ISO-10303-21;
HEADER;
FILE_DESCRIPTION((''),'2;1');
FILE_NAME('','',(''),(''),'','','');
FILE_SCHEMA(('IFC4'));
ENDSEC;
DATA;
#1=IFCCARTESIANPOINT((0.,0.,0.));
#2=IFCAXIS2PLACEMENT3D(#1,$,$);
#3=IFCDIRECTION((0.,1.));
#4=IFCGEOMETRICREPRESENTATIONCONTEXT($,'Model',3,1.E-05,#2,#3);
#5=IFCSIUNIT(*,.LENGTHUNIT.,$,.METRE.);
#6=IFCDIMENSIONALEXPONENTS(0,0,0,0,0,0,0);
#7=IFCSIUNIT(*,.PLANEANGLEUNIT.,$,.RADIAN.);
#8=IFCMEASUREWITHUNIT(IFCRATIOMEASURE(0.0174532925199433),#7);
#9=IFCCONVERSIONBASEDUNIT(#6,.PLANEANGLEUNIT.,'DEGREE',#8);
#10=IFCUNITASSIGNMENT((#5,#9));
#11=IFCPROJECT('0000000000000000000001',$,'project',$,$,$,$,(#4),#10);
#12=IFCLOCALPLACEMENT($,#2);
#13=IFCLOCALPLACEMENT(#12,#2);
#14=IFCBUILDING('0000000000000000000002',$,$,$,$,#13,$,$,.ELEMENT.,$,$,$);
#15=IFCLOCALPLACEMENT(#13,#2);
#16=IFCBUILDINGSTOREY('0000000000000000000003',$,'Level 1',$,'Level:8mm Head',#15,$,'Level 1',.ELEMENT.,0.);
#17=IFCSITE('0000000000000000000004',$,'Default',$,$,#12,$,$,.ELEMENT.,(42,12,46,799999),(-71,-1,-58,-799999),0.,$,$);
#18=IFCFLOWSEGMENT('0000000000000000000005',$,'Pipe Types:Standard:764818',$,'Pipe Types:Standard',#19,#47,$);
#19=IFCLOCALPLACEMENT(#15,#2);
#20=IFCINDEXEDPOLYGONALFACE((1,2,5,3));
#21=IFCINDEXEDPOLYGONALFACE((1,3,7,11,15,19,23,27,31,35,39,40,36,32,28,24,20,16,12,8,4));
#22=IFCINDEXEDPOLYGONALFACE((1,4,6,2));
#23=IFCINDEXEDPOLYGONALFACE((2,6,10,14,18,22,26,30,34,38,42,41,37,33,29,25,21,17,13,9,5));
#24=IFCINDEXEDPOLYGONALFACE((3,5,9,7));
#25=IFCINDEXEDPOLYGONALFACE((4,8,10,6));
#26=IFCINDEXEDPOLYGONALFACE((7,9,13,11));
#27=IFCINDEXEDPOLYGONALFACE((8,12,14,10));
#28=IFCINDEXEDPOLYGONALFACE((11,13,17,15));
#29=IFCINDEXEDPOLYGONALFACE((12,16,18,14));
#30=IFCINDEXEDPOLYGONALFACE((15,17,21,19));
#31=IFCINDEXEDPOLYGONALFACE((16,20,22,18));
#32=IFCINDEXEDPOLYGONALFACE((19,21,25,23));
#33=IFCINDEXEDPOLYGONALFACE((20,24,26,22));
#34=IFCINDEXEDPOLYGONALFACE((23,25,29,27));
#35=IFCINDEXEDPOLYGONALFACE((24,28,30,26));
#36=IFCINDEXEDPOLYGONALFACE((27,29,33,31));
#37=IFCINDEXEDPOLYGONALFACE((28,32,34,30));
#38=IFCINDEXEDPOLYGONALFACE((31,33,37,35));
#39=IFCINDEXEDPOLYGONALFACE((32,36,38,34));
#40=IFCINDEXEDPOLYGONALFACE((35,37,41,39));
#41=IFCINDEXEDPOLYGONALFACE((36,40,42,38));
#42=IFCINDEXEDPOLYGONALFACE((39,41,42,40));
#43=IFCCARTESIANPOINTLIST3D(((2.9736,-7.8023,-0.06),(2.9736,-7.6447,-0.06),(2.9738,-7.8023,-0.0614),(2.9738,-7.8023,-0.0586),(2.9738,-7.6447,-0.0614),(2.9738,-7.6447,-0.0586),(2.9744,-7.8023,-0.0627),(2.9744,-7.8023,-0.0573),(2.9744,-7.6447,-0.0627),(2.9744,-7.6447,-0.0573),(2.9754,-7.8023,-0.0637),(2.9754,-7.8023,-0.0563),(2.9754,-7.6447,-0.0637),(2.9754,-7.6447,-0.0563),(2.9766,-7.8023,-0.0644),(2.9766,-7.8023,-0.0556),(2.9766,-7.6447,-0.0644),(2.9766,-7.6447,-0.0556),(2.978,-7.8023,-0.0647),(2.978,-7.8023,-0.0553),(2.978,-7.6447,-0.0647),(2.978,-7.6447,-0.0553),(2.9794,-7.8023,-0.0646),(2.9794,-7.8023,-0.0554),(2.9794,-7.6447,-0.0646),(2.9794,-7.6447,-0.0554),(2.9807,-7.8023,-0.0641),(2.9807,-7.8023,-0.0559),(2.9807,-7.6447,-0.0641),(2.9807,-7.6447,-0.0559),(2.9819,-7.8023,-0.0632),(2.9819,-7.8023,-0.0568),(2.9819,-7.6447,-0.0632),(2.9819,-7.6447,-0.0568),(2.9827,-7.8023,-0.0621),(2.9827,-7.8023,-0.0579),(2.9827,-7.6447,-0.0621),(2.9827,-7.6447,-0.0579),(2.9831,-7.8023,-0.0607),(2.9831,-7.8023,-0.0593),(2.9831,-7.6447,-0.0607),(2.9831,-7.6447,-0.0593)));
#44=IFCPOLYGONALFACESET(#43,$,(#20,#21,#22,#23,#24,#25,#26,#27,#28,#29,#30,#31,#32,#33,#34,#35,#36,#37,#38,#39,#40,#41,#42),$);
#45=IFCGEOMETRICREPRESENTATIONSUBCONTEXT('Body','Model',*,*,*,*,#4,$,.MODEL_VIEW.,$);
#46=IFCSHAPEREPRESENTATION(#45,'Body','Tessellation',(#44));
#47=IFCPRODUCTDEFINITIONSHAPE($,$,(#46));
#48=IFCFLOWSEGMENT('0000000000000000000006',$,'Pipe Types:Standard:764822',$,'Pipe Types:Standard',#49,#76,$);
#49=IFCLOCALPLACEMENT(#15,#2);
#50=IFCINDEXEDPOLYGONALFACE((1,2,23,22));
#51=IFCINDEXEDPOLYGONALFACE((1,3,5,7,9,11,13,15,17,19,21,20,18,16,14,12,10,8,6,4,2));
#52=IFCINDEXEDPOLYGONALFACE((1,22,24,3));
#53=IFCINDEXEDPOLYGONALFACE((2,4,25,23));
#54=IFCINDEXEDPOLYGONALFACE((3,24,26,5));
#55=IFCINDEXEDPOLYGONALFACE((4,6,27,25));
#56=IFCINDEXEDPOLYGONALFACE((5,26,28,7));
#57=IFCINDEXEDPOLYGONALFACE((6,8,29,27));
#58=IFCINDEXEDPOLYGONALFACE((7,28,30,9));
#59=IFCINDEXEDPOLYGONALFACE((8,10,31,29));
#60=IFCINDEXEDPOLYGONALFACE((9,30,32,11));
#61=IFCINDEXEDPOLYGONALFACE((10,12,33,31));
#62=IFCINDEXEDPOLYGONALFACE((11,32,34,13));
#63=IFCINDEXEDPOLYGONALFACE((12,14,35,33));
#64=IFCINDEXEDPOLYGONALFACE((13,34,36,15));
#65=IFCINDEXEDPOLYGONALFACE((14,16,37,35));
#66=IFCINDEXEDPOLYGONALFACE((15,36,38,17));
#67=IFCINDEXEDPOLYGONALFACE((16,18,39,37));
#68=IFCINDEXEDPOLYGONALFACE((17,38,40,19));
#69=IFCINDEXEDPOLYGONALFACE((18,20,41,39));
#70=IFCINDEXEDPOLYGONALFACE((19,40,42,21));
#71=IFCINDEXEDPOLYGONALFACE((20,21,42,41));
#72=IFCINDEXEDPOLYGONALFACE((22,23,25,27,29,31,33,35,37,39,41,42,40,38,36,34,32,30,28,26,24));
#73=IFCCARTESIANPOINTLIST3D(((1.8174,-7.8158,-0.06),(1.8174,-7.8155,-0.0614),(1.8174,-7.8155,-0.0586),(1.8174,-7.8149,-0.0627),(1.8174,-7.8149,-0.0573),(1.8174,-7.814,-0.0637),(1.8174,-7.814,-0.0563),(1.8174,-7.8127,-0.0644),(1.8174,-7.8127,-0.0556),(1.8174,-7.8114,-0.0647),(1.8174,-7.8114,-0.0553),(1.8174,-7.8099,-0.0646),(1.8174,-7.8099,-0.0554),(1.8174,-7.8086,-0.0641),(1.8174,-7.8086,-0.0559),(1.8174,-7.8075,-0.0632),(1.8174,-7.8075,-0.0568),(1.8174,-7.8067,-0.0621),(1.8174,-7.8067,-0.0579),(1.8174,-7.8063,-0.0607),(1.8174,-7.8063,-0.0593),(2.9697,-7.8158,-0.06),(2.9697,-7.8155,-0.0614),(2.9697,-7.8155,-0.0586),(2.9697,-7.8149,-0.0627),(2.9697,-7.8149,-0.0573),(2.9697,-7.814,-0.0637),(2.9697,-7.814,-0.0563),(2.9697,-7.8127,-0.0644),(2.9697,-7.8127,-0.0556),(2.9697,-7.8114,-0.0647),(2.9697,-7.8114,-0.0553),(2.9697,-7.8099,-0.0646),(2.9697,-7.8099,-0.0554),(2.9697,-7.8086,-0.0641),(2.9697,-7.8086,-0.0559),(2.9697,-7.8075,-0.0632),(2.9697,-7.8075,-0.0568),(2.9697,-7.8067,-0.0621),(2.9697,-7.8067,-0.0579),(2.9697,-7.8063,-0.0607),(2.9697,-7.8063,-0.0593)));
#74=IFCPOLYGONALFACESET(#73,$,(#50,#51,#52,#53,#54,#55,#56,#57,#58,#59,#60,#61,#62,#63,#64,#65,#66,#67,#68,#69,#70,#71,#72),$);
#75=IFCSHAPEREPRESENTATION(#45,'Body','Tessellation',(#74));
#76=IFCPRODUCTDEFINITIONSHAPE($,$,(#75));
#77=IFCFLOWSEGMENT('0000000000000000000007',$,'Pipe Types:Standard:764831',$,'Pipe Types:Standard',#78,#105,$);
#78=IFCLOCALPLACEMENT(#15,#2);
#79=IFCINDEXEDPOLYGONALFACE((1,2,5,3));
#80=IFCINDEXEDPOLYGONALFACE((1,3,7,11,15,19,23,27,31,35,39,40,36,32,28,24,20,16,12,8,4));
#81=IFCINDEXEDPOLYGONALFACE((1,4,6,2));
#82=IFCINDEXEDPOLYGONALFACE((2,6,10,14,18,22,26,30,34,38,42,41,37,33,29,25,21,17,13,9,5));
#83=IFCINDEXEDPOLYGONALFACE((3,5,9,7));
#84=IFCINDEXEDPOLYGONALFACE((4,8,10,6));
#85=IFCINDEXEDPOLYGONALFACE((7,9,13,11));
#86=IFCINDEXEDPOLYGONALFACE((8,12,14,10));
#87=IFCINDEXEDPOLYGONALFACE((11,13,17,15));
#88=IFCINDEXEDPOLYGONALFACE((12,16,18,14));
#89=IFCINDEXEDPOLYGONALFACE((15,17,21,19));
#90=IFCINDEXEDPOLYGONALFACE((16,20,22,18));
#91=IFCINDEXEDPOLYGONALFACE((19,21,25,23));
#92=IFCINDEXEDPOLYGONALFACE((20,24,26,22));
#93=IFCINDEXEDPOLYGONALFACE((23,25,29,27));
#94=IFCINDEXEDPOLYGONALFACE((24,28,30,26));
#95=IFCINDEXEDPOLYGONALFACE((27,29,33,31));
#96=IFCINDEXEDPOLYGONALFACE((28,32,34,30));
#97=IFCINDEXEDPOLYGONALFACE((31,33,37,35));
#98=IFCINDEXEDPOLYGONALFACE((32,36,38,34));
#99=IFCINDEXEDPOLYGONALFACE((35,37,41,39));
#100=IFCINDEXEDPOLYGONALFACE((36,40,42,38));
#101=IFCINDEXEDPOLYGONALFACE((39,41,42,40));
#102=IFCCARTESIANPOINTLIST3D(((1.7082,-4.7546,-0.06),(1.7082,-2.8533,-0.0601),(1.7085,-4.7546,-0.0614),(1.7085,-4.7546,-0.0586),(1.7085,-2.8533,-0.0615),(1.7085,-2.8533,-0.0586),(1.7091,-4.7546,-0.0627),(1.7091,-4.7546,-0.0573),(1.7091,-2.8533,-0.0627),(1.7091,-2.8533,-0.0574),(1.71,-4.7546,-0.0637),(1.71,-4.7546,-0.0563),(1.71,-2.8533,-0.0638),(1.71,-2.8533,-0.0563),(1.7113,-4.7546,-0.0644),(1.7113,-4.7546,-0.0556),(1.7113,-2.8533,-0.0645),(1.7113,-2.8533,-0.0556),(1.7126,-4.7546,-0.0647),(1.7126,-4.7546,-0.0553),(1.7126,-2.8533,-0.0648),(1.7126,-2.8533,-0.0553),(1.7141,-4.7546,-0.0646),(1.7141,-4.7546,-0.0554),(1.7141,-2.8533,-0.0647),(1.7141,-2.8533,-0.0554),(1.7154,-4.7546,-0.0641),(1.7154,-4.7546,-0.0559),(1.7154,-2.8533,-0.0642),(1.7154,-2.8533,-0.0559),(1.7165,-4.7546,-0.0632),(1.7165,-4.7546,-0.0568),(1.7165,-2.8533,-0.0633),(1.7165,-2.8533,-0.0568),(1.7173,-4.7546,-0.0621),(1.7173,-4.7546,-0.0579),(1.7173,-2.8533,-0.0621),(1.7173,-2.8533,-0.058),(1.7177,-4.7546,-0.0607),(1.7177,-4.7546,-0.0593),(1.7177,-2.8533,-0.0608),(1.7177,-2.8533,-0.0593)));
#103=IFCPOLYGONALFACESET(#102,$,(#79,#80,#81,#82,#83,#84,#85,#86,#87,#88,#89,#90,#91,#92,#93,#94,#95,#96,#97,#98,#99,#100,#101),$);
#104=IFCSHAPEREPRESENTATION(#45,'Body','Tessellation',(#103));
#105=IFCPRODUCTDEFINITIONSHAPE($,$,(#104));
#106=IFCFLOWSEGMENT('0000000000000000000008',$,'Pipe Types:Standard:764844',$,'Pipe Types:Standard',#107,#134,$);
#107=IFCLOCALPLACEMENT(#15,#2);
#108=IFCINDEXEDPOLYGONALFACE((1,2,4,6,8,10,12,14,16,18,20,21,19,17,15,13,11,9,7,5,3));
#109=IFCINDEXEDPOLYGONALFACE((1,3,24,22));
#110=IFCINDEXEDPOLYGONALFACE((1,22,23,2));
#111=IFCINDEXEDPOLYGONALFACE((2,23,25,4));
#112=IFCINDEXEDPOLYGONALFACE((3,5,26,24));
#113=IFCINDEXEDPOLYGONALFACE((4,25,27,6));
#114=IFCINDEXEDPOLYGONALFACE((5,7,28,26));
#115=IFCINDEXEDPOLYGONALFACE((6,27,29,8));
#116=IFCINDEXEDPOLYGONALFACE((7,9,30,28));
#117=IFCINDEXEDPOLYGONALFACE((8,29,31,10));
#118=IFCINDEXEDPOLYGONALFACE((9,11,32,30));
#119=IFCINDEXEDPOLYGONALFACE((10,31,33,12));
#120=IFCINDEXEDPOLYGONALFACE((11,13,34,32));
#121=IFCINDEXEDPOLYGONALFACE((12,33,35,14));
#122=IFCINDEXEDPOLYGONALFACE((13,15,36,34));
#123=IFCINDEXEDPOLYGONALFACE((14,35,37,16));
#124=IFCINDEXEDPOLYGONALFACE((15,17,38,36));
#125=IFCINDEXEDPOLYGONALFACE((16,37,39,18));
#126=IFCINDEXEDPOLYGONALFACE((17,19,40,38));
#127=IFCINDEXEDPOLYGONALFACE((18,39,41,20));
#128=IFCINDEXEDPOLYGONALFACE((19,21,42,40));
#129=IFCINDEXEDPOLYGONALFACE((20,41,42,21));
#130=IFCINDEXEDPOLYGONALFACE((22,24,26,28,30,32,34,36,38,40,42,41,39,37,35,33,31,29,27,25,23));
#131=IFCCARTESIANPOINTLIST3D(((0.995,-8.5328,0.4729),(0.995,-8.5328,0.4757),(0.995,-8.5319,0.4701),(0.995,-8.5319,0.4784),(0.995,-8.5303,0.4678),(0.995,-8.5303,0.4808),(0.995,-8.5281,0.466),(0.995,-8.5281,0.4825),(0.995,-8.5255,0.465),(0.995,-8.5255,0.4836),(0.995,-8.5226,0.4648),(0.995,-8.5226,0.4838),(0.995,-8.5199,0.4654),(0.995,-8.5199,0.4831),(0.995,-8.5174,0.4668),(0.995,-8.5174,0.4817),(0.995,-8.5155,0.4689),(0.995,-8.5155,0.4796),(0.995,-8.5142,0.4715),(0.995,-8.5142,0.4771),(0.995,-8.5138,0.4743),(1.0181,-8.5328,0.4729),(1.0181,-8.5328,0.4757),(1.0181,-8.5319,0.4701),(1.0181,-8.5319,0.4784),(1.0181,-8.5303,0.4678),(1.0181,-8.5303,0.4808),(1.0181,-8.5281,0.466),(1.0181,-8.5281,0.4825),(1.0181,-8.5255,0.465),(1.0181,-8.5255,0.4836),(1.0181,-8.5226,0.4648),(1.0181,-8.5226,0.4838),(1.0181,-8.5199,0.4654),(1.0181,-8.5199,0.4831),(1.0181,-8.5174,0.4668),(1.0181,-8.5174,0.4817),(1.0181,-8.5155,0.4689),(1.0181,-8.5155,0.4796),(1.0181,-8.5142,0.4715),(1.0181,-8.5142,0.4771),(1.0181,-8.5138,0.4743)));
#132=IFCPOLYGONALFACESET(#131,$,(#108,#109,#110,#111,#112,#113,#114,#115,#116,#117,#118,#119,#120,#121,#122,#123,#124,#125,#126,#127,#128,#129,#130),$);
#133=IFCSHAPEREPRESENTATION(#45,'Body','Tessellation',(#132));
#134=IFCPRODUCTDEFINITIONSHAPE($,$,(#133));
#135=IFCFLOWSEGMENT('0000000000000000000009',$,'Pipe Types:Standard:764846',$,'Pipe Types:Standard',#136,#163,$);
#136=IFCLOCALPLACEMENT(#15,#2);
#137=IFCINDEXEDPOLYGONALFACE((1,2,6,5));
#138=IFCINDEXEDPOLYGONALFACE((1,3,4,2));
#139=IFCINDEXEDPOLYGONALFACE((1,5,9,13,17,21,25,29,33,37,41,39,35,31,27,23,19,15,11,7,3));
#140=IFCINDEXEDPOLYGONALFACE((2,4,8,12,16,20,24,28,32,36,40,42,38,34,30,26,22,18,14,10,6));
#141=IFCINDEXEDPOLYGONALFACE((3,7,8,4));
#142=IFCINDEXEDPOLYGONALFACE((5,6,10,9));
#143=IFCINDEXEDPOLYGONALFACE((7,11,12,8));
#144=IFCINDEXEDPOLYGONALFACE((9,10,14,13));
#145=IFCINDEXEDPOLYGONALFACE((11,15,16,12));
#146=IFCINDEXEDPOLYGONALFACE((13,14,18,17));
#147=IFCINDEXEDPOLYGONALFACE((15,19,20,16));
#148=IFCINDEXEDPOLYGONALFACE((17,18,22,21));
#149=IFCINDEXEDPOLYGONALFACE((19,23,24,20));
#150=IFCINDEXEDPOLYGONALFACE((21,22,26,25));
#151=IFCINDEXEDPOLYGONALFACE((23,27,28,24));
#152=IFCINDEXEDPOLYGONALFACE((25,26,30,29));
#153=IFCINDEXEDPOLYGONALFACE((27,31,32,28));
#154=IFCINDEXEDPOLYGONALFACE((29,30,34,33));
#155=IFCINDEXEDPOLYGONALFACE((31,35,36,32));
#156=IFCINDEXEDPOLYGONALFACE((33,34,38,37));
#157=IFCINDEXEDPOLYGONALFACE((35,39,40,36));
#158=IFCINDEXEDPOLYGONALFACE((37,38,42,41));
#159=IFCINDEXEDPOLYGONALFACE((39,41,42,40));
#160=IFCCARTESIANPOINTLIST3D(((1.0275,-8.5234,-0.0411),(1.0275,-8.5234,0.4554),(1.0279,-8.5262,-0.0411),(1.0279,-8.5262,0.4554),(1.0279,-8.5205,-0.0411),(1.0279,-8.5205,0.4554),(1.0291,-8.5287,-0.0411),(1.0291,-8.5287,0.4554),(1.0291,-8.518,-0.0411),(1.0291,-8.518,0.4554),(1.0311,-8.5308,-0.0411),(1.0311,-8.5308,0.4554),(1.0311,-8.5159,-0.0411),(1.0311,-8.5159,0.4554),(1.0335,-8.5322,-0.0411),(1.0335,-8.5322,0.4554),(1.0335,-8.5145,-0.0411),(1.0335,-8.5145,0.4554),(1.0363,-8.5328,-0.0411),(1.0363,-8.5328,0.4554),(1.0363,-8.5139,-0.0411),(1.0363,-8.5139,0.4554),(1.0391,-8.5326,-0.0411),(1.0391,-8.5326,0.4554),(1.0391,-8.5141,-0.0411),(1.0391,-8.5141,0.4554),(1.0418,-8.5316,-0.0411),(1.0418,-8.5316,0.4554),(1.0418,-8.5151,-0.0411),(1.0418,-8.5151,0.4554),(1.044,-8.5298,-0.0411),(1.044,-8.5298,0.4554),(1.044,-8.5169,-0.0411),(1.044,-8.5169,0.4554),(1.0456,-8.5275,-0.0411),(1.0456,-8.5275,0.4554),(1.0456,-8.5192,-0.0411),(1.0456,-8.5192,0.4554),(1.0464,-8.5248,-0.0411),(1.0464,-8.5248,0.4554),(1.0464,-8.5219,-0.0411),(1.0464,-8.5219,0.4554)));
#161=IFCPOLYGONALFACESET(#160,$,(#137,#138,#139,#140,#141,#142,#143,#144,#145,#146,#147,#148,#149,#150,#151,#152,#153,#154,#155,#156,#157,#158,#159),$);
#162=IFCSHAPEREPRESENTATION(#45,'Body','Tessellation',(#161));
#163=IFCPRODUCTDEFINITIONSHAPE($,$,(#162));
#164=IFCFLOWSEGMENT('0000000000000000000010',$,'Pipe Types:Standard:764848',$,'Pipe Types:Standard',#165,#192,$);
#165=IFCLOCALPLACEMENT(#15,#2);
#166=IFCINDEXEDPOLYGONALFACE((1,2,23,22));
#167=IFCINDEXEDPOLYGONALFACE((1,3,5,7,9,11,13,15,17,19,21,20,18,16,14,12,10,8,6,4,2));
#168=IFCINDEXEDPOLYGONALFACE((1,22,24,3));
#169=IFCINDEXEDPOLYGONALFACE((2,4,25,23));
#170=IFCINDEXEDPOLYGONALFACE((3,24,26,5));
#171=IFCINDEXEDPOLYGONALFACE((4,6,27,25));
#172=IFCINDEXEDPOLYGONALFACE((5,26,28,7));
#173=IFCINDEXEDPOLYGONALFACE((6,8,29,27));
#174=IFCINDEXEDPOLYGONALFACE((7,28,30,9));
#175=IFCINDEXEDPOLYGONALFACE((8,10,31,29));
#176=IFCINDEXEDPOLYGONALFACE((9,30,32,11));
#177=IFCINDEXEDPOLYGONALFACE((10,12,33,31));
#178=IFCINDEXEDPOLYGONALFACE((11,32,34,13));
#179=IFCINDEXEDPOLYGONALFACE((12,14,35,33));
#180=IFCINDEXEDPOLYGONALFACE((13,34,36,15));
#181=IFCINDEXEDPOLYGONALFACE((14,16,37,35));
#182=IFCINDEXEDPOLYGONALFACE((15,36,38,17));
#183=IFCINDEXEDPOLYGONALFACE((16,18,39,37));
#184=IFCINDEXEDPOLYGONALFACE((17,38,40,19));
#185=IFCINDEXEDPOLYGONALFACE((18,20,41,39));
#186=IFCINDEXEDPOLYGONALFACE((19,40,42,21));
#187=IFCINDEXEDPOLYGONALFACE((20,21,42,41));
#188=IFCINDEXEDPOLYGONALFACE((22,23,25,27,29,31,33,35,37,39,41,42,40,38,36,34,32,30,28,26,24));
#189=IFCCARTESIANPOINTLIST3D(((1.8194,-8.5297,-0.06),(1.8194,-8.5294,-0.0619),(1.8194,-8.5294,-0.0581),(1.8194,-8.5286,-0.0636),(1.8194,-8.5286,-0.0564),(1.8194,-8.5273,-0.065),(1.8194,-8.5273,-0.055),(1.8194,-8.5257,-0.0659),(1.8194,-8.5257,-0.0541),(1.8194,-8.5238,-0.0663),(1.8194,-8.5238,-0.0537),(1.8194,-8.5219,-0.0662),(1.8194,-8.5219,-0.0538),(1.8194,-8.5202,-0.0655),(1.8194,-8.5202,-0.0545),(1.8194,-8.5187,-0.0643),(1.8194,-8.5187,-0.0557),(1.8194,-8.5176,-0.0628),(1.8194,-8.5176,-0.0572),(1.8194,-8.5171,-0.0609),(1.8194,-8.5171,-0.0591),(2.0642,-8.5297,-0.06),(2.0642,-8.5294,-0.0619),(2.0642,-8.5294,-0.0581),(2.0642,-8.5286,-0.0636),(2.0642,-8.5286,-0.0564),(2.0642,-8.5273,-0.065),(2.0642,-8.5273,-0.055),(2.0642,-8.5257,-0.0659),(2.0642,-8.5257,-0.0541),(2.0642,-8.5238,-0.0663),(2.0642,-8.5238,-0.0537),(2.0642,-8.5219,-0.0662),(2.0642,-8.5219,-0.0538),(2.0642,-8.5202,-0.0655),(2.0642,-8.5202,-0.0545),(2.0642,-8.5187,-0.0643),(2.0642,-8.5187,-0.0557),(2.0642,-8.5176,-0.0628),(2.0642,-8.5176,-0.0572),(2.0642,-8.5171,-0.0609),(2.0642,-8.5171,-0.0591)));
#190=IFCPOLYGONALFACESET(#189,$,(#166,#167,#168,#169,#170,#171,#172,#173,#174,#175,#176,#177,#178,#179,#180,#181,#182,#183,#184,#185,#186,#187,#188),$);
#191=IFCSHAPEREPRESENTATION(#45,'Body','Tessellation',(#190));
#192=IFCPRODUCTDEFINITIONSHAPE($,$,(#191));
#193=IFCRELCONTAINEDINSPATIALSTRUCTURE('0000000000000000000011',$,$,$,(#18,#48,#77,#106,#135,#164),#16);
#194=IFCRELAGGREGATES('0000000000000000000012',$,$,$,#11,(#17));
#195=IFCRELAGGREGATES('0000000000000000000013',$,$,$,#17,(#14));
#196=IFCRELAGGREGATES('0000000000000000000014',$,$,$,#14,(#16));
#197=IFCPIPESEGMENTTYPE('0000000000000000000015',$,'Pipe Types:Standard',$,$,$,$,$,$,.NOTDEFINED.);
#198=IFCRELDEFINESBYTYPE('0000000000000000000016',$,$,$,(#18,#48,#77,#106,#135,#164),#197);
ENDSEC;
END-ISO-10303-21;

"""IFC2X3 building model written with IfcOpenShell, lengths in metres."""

from ifc_helpers import new_model, entity, si_unit, converted_unit, direction, frame, frame_2d, origin, origin_2d_with_axis, place, context, subcontext, project, spatial, circle, extrude, type_object, element, save


model = new_model("IFC2X3")

# Units and contexts
model_context = context("Model", 3, precision=1e-05, world=origin(), true_north=direction((0.0, 1.0)))
body_context = subcontext(model_context, "Body", "Model", "MODEL_VIEW")
ifc_project = project(units=[si_unit("LENGTHUNIT", "METRE"), converted_unit("PLANEANGLEUNIT", "DEGREE", entity("IfcRatioMeasure", 0.0174532925199433), si_unit("PLANEANGLEUNIT", "RADIAN"), dimensions=[0, 0, 0, 0, 0, 0, 0])], contexts=[model_context])

# Site, building, storey
site_placement = place(None, origin())
site = spatial("IfcSite", under=ifc_project, at=site_placement, Name="Default", CompositionType="ELEMENT", RefLatitude=(42, 12, 46, 799999), RefLongitude=(-71, -1, -58, -799999), RefElevation=0.0)
building_placement = place(site_placement, origin())
building = spatial("IfcBuilding", under=site, at=building_placement, CompositionType="ELEMENT")
storey_placement = place(building_placement, origin())
storey = spatial("IfcBuildingStorey", under=building, at=storey_placement, Name="Level 1", ObjectType="Level:8mm Head", LongName="Level 1", CompositionType="ELEMENT", Elevation=0.0)

# Flow segments
pipe_segment_type = type_object("IfcPipeSegmentType", Name="Pipe Types:Standard", PredefinedType="NOTDEFINED")
flow_segment_1_placement = place(storey_placement, origin())
element("IfcFlowSegment", 1, at=flow_segment_1_placement, inside=storey, type_object=pipe_segment_type, Name="Pipe Types:Standard:764818", ObjectType="Pipe Types:Standard", context=body_context, shape_type="SweptSolid", body=[
    extrude(circle(Radius=0.0048, at=frame_2d((0.0, 0.0), x_axis=(1.0, 0.0))), frame((2.9784, -7.8023, -0.06), z_axis=(0.0, 1.0, 0.0), x_axis=(-1.0, 0.0, 0.0)), (0.0, 0.0, 1.0), 0.1576),
])
flow_segment_2_placement = place(storey_placement, origin())
element("IfcFlowSegment", 2, at=flow_segment_2_placement, inside=storey, type_object=pipe_segment_type, Name="Pipe Types:Standard:764822", ObjectType="Pipe Types:Standard", context=body_context, shape_type="SweptSolid", body=[
    extrude(circle(Radius=0.0048, at=frame_2d((0.0, 0.0), x_axis=(1.0, 0.0))), frame((1.8174, -7.811, -0.06), z_axis=(1.0, 0.0, 0.0), x_axis=(0.0, -1.0, 0.0)), (0.0, 0.0, 1.0), 1.1522),
])
flow_segment_3_placement = place(storey_placement, origin())
element("IfcFlowSegment", 3, at=flow_segment_3_placement, inside=storey, type_object=pipe_segment_type, Name="Pipe Types:Standard:764831", ObjectType="Pipe Types:Standard", context=body_context, shape_type="SweptSolid", body=[
    extrude(circle(Radius=0.0048, at=frame_2d((0.0, 0.0), x_axis=(1.0, 0.0))), frame((1.713, -2.8533, -0.0601), z_axis=(0.0, -1.0, 0.000027), x_axis=(-1.0, 0.0, 0.0)), (0.0, 0.0, 1.0), 1.9012),
])
flow_segment_4_placement = place(storey_placement, origin())
element("IfcFlowSegment", 4, at=flow_segment_4_placement, inside=storey, type_object=pipe_segment_type, Name="Pipe Types:Standard:764844", ObjectType="Pipe Types:Standard", context=body_context, shape_type="SweptSolid", body=[
    extrude(circle(Radius=0.0095, at=frame_2d((0.0, 0.0), x_axis=(1.0, 0.0))), frame((0.995, -8.5234, 0.4743), z_axis=(1.0, 0.0, 0.0), x_axis=(0.0, 1.0, 0.0)), (0.0, 0.0, 1.0), 0.0231),
])
flow_segment_5_placement = place(storey_placement, origin())
element("IfcFlowSegment", 5, at=flow_segment_5_placement, inside=storey, type_object=pipe_segment_type, Name="Pipe Types:Standard:764846", ObjectType="Pipe Types:Standard", context=body_context, shape_type="SweptSolid", body=[
    extrude(circle(Radius=0.0095, at=origin_2d_with_axis()), frame((1.037, -8.5234, -0.0411), z_axis=(0.0, 0.0, 1.0), x_axis=(-1.0, 0.0, 0.0)), (0.0, 0.0, 1.0), 0.4965),
])
flow_segment_6_placement = place(storey_placement, origin())
element("IfcFlowSegment", 6, at=flow_segment_6_placement, inside=storey, type_object=pipe_segment_type, Name="Pipe Types:Standard:764848", ObjectType="Pipe Types:Standard", context=body_context, shape_type="SweptSolid", body=[
    extrude(circle(Radius=0.0063, at=frame_2d((0.0, 0.0), x_axis=(1.0, 0.0))), frame((1.8194, -8.5234, -0.06), z_axis=(1.0, 0.0, 0.0), x_axis=(0.0, -1.0, 0.0)), (0.0, 0.0, 1.0), 0.2448),
])

save(model, "model.ifc")
